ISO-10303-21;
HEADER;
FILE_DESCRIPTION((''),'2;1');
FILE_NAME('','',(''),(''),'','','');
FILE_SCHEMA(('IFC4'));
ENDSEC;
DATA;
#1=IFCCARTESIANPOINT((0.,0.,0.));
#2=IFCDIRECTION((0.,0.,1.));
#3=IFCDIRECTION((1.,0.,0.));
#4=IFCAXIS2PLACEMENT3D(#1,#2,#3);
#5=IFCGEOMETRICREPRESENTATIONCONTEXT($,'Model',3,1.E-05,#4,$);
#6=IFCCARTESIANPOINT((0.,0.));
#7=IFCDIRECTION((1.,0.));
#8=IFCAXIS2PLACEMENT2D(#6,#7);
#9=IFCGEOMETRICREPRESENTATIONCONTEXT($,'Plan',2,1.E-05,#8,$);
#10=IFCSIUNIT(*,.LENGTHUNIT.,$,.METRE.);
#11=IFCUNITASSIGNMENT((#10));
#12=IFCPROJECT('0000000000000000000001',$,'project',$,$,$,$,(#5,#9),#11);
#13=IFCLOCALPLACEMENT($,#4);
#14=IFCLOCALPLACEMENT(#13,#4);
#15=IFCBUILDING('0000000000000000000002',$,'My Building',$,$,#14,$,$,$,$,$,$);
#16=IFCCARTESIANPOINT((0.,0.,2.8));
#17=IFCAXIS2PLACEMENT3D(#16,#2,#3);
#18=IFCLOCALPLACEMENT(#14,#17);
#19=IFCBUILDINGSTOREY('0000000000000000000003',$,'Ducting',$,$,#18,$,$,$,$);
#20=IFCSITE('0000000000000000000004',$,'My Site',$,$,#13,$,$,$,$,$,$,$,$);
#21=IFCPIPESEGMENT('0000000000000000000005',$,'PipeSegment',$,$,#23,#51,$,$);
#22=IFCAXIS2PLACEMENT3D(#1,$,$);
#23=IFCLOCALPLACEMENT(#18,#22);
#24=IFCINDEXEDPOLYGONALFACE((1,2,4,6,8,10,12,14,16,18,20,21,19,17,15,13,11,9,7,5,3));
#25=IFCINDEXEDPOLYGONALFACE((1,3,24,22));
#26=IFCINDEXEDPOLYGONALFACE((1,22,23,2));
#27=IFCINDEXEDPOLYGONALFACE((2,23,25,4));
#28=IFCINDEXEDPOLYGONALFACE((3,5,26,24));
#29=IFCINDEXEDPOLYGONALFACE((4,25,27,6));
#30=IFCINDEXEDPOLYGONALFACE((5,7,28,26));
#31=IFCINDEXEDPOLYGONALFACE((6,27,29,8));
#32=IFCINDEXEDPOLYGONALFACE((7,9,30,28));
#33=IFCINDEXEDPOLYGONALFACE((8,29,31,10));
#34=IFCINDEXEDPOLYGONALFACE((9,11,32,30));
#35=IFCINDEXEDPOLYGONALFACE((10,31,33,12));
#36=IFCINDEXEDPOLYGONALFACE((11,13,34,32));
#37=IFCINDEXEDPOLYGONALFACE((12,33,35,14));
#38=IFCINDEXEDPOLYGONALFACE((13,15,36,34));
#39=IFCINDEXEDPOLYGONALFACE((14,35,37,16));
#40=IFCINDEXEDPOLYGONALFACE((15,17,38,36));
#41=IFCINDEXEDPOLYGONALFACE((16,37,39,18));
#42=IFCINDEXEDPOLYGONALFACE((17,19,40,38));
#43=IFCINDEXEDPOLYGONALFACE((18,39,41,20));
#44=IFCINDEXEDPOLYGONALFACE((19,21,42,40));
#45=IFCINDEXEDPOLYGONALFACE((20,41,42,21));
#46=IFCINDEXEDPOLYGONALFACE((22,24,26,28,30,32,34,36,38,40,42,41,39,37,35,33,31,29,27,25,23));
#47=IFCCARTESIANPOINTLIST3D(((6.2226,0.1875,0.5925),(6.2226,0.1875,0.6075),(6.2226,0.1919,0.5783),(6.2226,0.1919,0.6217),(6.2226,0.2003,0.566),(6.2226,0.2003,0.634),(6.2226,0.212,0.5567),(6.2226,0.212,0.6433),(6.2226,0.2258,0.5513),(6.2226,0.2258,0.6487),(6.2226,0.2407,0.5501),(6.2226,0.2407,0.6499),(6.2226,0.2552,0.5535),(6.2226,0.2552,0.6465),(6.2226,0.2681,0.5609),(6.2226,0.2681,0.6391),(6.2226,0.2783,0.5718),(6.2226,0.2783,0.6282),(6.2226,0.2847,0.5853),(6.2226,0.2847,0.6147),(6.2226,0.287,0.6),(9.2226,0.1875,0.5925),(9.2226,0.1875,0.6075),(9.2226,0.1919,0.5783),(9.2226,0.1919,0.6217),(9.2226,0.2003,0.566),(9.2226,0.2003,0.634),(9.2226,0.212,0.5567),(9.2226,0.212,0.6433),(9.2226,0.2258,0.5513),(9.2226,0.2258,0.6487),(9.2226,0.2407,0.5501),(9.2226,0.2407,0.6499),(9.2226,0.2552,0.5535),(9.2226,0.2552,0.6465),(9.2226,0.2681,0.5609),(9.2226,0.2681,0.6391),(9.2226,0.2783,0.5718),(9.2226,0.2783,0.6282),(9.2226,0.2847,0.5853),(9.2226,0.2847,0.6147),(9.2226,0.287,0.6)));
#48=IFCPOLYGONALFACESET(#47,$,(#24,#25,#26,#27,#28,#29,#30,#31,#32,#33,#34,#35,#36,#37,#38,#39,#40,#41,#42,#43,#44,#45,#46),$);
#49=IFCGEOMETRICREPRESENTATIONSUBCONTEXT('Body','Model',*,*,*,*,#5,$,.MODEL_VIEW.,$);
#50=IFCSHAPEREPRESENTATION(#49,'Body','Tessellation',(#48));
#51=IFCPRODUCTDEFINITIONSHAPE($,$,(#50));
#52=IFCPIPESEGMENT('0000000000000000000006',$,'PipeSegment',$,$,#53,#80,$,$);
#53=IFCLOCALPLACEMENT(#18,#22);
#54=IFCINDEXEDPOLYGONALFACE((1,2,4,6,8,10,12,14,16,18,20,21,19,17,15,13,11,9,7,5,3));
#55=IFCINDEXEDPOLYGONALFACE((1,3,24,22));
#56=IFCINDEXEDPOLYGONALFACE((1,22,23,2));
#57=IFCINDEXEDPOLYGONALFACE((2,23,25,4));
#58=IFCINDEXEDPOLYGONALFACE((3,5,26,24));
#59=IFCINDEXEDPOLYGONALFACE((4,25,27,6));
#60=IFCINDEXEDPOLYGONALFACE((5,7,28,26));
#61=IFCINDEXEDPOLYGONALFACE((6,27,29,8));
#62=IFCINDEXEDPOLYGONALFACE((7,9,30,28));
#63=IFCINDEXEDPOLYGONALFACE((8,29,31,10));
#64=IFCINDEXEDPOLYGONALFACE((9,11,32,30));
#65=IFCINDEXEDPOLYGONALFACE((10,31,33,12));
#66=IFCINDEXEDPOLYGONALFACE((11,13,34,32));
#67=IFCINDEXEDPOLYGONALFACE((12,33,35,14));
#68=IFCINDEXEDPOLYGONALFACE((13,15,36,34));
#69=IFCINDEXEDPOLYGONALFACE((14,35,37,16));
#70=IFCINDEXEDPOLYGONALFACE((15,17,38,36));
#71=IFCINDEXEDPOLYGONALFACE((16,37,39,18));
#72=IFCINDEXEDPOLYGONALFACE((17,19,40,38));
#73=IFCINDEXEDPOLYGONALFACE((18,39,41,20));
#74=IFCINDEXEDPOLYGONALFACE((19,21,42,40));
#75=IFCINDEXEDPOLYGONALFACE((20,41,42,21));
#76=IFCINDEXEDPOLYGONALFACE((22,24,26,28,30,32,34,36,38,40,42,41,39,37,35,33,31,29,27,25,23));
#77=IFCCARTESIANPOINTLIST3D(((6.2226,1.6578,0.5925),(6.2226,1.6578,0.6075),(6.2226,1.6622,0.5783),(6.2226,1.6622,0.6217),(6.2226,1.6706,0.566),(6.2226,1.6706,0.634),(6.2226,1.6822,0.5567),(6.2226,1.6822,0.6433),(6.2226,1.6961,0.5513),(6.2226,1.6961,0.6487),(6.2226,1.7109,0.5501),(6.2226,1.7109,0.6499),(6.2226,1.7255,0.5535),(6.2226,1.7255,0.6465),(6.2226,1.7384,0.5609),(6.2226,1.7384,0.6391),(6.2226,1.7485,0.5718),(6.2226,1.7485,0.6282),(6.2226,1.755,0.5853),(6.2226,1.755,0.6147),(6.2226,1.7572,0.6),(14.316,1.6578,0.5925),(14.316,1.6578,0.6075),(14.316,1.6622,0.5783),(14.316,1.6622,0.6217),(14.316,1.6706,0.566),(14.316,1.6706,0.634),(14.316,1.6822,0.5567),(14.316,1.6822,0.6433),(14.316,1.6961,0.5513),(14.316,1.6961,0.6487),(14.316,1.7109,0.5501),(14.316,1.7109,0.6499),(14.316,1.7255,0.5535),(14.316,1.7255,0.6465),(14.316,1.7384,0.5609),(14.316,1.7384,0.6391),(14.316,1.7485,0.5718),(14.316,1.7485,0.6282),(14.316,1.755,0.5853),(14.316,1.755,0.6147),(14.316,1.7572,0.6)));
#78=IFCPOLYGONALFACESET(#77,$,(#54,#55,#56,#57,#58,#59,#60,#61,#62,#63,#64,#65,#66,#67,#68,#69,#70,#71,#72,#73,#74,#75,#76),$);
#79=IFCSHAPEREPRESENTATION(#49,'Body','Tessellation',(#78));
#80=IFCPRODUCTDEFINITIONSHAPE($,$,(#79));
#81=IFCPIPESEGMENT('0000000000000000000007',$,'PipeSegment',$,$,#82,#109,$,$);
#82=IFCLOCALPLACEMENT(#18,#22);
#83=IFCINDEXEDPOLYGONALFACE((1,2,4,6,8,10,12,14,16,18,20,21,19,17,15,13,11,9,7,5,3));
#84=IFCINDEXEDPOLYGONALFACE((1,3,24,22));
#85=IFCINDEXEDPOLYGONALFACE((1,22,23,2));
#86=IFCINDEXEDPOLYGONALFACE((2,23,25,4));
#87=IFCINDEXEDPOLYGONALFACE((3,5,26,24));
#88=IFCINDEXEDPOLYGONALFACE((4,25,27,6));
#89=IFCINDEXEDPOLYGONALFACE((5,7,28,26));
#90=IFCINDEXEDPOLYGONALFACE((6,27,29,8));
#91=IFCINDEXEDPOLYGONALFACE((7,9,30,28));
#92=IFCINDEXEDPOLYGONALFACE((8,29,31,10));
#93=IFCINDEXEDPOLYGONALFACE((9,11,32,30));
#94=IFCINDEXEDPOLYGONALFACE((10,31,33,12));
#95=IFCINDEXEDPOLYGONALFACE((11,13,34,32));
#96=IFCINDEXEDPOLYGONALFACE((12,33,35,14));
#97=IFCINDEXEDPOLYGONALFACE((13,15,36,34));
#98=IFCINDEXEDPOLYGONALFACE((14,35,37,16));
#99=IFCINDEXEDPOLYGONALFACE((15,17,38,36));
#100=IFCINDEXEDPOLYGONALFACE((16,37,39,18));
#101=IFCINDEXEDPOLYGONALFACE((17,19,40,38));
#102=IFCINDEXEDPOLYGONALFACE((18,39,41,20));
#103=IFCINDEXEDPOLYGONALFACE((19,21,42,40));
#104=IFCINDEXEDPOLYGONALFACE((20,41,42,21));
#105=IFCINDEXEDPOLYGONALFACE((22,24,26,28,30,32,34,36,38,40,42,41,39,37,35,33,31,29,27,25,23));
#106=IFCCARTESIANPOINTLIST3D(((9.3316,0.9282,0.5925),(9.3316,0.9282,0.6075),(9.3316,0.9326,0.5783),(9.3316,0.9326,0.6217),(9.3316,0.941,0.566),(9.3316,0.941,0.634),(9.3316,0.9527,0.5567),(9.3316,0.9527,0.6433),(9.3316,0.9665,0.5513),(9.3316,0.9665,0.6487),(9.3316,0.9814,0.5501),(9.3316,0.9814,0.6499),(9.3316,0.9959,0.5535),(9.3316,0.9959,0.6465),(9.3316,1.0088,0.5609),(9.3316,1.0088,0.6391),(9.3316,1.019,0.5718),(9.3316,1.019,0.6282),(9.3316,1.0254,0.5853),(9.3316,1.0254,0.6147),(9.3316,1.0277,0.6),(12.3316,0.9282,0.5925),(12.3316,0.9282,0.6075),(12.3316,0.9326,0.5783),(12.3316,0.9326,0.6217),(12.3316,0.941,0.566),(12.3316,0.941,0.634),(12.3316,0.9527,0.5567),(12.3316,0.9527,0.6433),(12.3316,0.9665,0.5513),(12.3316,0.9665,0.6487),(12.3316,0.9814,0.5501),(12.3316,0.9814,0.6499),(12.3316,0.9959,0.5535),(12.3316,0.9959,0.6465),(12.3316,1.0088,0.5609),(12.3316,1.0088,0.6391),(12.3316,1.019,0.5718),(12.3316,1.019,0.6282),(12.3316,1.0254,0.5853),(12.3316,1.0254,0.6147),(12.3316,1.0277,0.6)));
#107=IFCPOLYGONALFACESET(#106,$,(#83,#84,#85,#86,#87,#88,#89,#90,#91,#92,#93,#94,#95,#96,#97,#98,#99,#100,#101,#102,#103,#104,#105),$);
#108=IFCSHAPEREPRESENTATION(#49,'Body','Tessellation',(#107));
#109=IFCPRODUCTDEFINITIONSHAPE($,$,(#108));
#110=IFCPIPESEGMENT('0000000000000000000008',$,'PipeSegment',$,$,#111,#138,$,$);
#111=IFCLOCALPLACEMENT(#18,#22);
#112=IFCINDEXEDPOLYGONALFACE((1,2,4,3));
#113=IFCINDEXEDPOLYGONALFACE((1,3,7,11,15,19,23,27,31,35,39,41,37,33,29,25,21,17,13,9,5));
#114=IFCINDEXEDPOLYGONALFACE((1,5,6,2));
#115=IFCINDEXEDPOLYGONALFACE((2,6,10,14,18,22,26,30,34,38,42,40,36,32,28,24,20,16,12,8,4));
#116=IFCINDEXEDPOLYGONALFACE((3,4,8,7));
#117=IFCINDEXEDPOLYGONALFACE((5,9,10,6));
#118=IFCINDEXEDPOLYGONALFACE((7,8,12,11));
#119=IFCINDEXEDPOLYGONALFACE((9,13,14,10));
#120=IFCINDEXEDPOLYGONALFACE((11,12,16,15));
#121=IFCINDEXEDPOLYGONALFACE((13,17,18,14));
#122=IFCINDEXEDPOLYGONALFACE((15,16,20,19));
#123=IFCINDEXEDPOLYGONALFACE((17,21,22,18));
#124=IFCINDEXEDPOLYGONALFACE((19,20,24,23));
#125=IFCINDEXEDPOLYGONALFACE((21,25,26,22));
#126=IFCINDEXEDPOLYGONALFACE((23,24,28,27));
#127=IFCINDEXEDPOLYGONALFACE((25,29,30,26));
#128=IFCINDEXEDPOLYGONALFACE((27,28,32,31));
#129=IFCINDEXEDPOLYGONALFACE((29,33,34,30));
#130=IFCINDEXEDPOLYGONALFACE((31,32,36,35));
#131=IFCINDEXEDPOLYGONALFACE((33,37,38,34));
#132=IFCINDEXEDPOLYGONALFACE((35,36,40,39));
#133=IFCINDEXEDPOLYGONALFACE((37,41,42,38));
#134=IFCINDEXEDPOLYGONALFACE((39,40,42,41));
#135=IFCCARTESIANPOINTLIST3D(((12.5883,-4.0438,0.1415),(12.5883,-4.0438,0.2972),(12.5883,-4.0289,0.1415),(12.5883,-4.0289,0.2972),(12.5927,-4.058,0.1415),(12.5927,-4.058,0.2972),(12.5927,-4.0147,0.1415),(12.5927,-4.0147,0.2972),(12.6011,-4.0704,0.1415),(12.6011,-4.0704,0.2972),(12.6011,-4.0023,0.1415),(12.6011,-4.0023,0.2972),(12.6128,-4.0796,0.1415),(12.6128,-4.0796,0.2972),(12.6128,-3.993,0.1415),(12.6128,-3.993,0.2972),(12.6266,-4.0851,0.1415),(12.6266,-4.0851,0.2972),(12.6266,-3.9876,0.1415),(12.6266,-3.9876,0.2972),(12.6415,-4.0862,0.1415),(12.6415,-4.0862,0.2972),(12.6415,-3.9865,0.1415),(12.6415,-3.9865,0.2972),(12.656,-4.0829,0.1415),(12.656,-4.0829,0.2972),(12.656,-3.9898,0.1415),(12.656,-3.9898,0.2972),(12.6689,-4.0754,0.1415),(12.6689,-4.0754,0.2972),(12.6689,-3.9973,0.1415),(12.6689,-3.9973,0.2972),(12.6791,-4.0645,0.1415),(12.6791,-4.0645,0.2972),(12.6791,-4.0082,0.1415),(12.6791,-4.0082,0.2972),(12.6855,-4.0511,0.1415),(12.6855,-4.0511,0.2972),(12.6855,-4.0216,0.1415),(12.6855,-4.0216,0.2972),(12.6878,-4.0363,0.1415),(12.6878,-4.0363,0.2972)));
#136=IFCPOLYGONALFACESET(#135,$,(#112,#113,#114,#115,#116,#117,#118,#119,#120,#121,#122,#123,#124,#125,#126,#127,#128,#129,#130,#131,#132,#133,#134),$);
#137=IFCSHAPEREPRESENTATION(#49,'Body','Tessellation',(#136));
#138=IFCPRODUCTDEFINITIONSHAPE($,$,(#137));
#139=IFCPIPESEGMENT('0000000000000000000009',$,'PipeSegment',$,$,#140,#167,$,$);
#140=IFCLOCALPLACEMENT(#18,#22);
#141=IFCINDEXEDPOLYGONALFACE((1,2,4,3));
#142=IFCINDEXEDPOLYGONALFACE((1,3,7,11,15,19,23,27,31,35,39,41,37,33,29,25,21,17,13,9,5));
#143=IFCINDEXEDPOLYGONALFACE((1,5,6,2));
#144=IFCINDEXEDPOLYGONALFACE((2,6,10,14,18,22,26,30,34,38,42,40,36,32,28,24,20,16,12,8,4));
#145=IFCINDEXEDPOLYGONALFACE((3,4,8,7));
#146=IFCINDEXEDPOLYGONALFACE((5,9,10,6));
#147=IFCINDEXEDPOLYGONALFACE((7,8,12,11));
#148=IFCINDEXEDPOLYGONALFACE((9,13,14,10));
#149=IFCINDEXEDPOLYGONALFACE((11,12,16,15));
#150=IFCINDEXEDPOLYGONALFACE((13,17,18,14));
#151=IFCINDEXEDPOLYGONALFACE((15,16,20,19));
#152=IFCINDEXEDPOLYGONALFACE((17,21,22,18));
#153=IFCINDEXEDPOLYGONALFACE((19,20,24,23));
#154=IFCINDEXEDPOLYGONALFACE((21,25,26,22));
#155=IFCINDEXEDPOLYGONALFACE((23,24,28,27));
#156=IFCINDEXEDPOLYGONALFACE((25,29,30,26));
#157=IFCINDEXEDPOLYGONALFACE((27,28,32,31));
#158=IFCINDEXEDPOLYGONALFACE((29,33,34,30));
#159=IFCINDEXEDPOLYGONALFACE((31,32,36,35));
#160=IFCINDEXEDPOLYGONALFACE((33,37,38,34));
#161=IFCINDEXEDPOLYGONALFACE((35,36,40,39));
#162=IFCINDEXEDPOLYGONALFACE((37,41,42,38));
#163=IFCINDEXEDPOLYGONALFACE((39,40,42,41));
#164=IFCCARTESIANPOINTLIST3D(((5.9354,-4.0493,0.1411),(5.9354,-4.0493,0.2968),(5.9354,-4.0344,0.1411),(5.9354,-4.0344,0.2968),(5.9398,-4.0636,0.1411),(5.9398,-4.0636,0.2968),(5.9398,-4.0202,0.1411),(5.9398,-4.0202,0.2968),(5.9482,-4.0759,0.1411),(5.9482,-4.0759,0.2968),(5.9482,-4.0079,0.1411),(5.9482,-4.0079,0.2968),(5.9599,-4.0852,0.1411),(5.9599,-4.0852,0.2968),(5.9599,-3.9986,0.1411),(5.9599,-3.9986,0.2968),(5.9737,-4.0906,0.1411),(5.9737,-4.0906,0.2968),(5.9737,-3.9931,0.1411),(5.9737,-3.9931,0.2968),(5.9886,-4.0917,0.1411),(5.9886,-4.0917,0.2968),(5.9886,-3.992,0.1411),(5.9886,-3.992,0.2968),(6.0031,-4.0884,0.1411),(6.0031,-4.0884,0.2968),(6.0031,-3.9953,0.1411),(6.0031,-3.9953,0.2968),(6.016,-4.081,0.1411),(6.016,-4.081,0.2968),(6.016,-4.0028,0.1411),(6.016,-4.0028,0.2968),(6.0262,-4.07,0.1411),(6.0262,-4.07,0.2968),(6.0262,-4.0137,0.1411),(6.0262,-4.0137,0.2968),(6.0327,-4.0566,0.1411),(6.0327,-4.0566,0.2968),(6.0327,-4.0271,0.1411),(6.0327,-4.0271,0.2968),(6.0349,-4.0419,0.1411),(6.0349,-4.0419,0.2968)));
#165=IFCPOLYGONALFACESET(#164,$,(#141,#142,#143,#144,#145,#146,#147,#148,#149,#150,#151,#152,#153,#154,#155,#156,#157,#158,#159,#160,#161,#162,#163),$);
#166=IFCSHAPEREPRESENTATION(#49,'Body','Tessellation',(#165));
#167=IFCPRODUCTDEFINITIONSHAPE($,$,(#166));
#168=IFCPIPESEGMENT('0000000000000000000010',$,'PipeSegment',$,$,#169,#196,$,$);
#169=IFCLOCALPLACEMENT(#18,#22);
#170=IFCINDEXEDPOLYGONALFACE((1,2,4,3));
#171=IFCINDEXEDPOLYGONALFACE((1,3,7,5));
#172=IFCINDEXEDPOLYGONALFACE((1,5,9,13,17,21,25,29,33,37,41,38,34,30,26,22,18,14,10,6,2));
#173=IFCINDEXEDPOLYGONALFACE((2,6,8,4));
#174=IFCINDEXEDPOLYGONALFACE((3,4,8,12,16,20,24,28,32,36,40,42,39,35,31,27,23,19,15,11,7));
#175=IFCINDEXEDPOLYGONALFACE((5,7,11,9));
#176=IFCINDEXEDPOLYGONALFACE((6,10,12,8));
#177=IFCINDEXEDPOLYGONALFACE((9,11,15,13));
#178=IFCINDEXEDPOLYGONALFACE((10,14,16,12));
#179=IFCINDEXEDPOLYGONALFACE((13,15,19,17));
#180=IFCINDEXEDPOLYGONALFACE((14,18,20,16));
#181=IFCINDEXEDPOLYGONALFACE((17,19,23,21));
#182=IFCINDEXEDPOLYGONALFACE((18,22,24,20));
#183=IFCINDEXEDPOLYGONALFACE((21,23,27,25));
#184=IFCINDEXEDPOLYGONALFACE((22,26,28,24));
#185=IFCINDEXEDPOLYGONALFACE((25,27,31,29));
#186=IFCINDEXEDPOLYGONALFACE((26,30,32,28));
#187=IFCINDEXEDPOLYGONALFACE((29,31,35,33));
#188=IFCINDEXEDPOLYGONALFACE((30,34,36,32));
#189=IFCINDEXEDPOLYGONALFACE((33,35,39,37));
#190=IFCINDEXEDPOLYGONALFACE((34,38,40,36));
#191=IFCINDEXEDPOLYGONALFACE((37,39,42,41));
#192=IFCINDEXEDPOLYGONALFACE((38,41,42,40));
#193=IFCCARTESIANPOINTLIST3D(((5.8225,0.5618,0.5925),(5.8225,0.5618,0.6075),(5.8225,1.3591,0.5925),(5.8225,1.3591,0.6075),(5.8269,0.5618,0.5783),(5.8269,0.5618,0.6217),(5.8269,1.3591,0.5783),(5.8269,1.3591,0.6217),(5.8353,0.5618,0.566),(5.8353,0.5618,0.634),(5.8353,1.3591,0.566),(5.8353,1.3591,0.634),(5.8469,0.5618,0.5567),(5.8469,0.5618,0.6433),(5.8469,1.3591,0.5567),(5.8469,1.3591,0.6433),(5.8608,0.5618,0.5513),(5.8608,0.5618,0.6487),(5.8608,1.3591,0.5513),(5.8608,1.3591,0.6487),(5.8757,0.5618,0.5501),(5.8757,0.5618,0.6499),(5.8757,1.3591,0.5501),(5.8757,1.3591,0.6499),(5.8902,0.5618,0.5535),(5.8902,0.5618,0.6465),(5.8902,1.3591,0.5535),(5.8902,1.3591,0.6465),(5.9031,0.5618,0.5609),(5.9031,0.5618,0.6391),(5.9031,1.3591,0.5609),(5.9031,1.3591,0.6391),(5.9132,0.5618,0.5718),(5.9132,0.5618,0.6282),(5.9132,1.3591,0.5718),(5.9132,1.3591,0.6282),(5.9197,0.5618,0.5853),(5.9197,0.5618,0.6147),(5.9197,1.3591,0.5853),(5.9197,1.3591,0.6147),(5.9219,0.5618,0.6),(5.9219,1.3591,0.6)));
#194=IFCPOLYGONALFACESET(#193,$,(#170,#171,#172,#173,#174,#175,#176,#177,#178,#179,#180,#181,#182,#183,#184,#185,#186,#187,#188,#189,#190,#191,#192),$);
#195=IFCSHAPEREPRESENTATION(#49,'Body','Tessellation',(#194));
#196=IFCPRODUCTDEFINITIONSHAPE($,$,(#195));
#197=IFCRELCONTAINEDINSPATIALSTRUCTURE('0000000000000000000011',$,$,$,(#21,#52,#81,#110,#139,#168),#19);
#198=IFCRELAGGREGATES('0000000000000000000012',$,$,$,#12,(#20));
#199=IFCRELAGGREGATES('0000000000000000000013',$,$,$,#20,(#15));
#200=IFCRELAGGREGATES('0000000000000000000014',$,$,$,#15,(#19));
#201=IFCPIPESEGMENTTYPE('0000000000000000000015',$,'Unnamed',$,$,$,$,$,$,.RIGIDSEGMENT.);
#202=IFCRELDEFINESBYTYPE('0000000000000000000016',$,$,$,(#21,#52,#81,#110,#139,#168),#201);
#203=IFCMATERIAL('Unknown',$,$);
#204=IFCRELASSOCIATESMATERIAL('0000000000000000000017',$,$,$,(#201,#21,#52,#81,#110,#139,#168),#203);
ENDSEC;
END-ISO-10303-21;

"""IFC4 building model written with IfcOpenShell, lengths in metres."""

from ifc_helpers import new_model, si_unit, frame, origin_with_axes, origin_2d_with_axis, place, context, subcontext, project, spatial, circle, extrude, material, material_profile, profile_set, profile_usage, type_object, element, save


model = new_model("IFC4")

# Units and contexts
model_context = context("Model", 3, precision=1e-05, world=origin_with_axes())
plan_context = context("Plan", 2, precision=1e-05, world=origin_2d_with_axis())
body_context = subcontext(model_context, "Body", "Model", "MODEL_VIEW")
ifc_project = project(units=[si_unit("LENGTHUNIT", "METRE")], contexts=[model_context, plan_context])

# Site, building, storey
site_placement = place(None, origin_with_axes())
site = spatial("IfcSite", under=ifc_project, at=site_placement, Name="My Site")
building_placement = place(site_placement, origin_with_axes())
building = spatial("IfcBuilding", under=site, at=building_placement, Name="My Building")
storey_placement = place(building_placement, frame((0.0, 0.0, 2.8), z_axis=(0.0, 0.0, 1.0), x_axis=(1.0, 0.0, 0.0)))
storey = spatial("IfcBuildingStorey", under=building, at=storey_placement, Name="Ducting")

# Shared definitions
ifc_material = material(Name="Unknown")

# Pipe segments
ifc_material_profile_1 = material_profile(ifc_material, circle(Radius=0.05))
ifc_profile_set_1 = profile_set([ifc_material_profile_1])
pipe_segment_type = type_object("IfcPipeSegmentType", Name="Unnamed", PredefinedType="RIGIDSEGMENT", material=ifc_profile_set_1)
ifc_profile_usage_1 = profile_usage(ifc_profile_set_1, cardinal=5)
pipe_segment_1_placement = place(storey_placement, frame((6.2226, 0.237, 0.6), z_axis=(1.0, 0.0, 0.0), x_axis=(0.0, 1.0, 0.0)))
element("IfcPipeSegment", 1, at=pipe_segment_1_placement, inside=storey, type_object=pipe_segment_type, material=ifc_profile_usage_1, Name="PipeSegment", context=body_context, shape_type="SweptSolid", body=[
    extrude(circle(Radius=0.05), origin_with_axes(), (0.0, 0.0, 1.0), 3.0),
])
ifc_profile_usage_2 = profile_usage(ifc_profile_set_1, cardinal=5)
pipe_segment_2_placement = place(storey_placement, frame((6.2226, 1.7072, 0.6), z_axis=(1.0, 0.0, 0.0), x_axis=(0.0, 1.0, 0.0)))
element("IfcPipeSegment", 2, at=pipe_segment_2_placement, inside=storey, type_object=pipe_segment_type, material=ifc_profile_usage_2, Name="PipeSegment", context=body_context, shape_type="SweptSolid", body=[
    extrude(circle(Radius=0.05), origin_with_axes(), (0.0, 0.0, 1.0), 8.0934),
])
ifc_profile_usage_3 = profile_usage(ifc_profile_set_1, cardinal=5)
pipe_segment_3_placement = place(storey_placement, frame((9.3316, 0.9777, 0.6), z_axis=(1.0, 0.0, 0.0), x_axis=(0.0, 1.0, 0.0)))
element("IfcPipeSegment", 3, at=pipe_segment_3_placement, inside=storey, type_object=pipe_segment_type, material=ifc_profile_usage_3, Name="PipeSegment", context=body_context, shape_type="SweptSolid", body=[
    extrude(circle(Radius=0.05), origin_with_axes(), (0.0, 0.0, 1.0), 3.0),
])
ifc_profile_usage_4 = profile_usage(ifc_profile_set_1, cardinal=5)
pipe_segment_4_placement = place(storey_placement, frame((12.6378, -4.0363, 0.2972), z_axis=(0.0, 0.0, -1.0), x_axis=(1.0, 0.0, 0.0)))
element("IfcPipeSegment", 4, at=pipe_segment_4_placement, inside=storey, type_object=pipe_segment_type, material=ifc_profile_usage_4, Name="PipeSegment", context=body_context, shape_type="SweptSolid", body=[
    extrude(circle(Radius=0.05), origin_with_axes(), (0.0, 0.0, 1.0), 0.1557),
])
ifc_profile_usage_5 = profile_usage(ifc_profile_set_1, cardinal=5)
pipe_segment_5_placement = place(storey_placement, frame((5.9849, -4.0419, 0.2968), z_axis=(0.0, 0.0, -1.0), x_axis=(1.0, 0.0, 0.0)))
element("IfcPipeSegment", 5, at=pipe_segment_5_placement, inside=storey, type_object=pipe_segment_type, material=ifc_profile_usage_5, Name="PipeSegment", context=body_context, shape_type="SweptSolid", body=[
    extrude(circle(Radius=0.05), origin_with_axes(), (0.0, 0.0, 1.0), 0.1557),
])
ifc_profile_usage_6 = profile_usage(ifc_profile_set_1, cardinal=5)
pipe_segment_6_placement = place(storey_placement, frame((5.8719, 1.3591, 0.6), z_axis=(0.0, -1.0, 0.0), x_axis=(1.0, 0.0, 0.0)))
element("IfcPipeSegment", 6, at=pipe_segment_6_placement, inside=storey, type_object=pipe_segment_type, material=ifc_profile_usage_6, Name="PipeSegment", context=body_context, shape_type="SweptSolid", body=[
    extrude(circle(Radius=0.05), origin_with_axes(), (0.0, 0.0, 1.0), 0.7974),
])

save(model, "model.ifc")
